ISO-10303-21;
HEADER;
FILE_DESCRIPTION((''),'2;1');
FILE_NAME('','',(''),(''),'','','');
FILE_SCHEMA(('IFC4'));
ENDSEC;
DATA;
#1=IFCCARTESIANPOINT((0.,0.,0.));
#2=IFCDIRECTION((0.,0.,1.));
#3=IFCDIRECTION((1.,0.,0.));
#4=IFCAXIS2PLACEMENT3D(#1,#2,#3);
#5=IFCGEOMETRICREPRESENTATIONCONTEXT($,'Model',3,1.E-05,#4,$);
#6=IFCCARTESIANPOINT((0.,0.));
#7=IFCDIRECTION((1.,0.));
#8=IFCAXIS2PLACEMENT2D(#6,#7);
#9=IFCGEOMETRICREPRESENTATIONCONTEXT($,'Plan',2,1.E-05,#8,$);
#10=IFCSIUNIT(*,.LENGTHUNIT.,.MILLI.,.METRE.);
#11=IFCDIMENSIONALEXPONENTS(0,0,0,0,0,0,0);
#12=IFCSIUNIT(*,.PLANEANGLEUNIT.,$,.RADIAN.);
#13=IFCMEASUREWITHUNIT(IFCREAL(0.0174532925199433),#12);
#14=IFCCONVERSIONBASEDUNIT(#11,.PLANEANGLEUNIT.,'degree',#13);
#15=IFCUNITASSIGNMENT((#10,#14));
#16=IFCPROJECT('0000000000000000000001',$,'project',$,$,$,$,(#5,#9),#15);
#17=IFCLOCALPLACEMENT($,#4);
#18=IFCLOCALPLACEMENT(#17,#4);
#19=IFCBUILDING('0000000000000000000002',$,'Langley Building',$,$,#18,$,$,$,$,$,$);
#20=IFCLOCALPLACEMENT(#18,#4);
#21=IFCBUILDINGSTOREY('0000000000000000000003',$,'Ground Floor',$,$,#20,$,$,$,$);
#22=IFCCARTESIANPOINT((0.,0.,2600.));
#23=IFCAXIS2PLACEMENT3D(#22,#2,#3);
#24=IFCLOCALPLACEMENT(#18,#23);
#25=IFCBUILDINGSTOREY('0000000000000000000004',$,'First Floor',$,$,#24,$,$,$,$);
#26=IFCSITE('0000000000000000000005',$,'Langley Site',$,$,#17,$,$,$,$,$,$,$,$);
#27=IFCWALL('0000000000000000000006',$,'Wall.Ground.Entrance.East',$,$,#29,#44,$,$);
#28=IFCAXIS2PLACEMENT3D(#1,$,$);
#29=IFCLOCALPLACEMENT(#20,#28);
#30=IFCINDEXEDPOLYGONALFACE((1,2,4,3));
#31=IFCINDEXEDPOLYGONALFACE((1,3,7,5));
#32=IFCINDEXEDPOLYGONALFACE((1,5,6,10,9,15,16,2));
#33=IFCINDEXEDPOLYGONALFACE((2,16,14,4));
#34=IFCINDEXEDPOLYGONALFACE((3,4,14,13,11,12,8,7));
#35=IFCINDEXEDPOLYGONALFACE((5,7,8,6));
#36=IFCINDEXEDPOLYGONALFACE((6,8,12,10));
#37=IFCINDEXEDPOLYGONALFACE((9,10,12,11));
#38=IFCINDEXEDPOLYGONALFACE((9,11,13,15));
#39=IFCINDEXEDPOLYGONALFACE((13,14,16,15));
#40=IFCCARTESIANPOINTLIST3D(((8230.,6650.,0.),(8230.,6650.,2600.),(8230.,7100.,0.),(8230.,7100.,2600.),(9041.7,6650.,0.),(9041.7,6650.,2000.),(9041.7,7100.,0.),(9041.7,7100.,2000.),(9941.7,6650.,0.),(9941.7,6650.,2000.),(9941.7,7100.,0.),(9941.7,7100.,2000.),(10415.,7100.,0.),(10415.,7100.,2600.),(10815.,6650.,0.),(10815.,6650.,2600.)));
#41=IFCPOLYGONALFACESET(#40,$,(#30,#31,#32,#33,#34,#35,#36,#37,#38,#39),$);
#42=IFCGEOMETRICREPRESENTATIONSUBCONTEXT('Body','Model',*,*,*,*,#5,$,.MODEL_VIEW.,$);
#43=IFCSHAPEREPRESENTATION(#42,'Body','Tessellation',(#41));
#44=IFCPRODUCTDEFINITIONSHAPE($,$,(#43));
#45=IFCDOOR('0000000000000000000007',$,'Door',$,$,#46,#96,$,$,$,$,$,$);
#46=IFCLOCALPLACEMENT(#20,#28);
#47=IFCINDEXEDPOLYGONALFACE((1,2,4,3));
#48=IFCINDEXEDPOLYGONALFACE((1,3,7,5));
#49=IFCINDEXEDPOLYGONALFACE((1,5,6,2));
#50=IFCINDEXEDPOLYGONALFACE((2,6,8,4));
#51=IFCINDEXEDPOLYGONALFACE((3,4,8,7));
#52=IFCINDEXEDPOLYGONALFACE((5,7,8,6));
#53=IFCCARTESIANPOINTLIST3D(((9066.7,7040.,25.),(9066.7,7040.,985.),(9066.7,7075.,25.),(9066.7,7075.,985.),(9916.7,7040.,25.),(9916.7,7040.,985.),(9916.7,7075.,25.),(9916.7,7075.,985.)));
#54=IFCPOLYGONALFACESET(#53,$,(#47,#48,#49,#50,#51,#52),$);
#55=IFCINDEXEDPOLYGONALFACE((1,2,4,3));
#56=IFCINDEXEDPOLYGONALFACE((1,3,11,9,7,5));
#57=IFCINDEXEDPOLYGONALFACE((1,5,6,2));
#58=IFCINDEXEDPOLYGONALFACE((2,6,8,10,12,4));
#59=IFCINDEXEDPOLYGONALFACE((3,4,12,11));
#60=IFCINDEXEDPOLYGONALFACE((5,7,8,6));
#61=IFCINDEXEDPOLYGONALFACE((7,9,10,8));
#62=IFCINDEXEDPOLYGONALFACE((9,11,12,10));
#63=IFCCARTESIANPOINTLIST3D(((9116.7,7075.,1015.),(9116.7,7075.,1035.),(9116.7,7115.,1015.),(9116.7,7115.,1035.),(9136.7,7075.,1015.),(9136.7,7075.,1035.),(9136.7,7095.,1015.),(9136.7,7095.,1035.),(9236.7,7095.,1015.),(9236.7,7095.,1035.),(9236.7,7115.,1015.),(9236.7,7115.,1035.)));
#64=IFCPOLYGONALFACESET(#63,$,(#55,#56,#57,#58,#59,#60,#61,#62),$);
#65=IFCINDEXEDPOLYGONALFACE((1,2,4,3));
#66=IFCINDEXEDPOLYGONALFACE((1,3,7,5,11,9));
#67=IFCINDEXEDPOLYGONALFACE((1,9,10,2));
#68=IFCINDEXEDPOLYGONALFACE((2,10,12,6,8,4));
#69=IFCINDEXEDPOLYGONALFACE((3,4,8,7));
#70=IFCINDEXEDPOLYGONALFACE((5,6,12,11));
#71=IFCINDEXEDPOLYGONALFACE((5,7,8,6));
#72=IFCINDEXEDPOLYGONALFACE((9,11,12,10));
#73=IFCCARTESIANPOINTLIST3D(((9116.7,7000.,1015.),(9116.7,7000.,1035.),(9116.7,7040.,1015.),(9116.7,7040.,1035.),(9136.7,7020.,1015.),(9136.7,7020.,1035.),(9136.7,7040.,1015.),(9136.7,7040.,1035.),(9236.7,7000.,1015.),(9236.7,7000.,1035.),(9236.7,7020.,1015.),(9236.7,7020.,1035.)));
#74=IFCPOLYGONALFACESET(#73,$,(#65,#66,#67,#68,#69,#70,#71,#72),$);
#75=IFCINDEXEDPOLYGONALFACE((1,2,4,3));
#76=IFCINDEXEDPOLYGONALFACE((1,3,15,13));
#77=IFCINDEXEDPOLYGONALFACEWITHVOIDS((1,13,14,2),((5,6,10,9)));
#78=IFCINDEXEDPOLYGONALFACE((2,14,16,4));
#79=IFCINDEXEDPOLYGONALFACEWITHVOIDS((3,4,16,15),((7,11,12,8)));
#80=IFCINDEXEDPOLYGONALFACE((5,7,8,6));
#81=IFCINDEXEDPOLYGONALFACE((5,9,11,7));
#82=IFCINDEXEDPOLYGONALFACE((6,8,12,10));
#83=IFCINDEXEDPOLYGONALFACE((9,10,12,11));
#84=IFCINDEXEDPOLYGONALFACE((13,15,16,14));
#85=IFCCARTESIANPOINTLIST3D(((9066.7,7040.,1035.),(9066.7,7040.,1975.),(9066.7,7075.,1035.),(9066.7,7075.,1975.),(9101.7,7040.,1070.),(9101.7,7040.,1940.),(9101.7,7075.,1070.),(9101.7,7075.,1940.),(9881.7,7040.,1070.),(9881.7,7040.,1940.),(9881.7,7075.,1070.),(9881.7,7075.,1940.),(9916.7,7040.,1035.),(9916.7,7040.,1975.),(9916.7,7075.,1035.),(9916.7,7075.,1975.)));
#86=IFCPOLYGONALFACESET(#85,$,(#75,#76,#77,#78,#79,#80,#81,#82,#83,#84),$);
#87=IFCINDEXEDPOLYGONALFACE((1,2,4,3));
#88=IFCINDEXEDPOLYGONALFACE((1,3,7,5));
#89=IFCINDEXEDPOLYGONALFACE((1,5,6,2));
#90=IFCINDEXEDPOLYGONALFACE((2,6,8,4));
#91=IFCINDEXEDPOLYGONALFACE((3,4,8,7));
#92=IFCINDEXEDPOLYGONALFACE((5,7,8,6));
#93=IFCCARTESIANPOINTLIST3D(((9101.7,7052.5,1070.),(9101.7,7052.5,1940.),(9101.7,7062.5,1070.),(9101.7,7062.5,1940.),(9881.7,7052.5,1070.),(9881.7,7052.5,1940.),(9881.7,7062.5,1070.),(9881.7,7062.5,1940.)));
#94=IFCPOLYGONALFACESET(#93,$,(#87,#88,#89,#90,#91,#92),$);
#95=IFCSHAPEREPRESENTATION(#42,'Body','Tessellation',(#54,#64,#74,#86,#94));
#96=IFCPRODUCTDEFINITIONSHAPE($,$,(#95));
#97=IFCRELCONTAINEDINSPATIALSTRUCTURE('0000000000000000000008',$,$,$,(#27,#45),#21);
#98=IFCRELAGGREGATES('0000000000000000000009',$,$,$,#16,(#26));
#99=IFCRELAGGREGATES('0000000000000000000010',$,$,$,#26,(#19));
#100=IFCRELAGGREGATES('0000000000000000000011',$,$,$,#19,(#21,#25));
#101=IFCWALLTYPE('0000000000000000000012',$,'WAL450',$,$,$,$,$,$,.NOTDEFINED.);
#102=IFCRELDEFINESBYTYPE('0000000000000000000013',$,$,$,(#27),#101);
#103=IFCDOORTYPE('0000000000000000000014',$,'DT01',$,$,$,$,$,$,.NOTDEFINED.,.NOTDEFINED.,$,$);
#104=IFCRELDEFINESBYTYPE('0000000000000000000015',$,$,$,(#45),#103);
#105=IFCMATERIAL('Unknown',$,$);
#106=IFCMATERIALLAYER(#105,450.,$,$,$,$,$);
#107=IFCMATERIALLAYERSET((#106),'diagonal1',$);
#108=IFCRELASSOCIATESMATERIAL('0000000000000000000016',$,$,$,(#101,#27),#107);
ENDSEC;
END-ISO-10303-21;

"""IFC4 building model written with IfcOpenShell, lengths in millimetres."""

from ifc_helpers import new_model, entity, si_unit, converted_unit, frame, origin_with_axes, origin_2d_with_axis, place, context, subcontext, project, spatial, line, indexed_curve, outline, extrude, shape, source, transform, mapped, material, layer, layer_set, layer_usage, type_object, type_shapes, element, fill, save


model = new_model("IFC4")

# Units and contexts
model_context = context("Model", 3, precision=1e-05, world=origin_with_axes())
plan_context = context("Plan", 2, precision=1e-05, world=origin_2d_with_axis())
body_context_1 = subcontext(model_context, "Body", "Model", "MODEL_VIEW")
body_context_2 = subcontext(plan_context, "Body", "Plan", "PLAN_VIEW")
ifc_project = project(units=[si_unit("LENGTHUNIT", "METRE", prefix="MILLI"), converted_unit("PLANEANGLEUNIT", "degree", entity("IfcReal", 0.0174532925199433), si_unit("PLANEANGLEUNIT", "RADIAN"), dimensions=[0, 0, 0, 0, 0, 0, 0])], contexts=[model_context, plan_context])

# Site, building, storey
site_placement = place(None, origin_with_axes())
site = spatial("IfcSite", under=ifc_project, at=site_placement, Name="Langley Site")
building_placement = place(site_placement, origin_with_axes())
building = spatial("IfcBuilding", under=site, at=building_placement, Name="Langley Building")
storey_1_placement = place(building_placement, origin_with_axes())
storey_1 = spatial("IfcBuildingStorey", under=building, at=storey_1_placement, Name="Ground Floor")

# Shared definitions
ifc_material = material(Name="Unknown")

# Shared definitions
storey_2_placement = place(building_placement, frame((0.0, 0.0, 2600.0), z_axis=(0.0, 0.0, 1.0), x_axis=(1.0, 0.0, 0.0)))
storey_2 = spatial("IfcBuildingStorey", under=building, at=storey_2_placement, Name="First Floor")

# Shared definitions
ifc_layer_1 = layer(ifc_material, 450.0)
ifc_layer_set_1 = layer_set([ifc_layer_1], Name="diagonal1")
wall_type_1 = type_object("IfcWallType", Name="WAL450", PredefinedType="NOTDEFINED", material=ifc_layer_set_1)

# Wall, opening, door
ifc_layer_usage_1 = layer_usage(ifc_layer_set_1, "AXIS2", "POSITIVE", 0.0)
wall_1_placement = place(storey_1_placement, frame((10815.0, 7100.0, 0.0), z_axis=(0.0, 0.0, 1.0), x_axis=(-1.0, 0.0, 0.0)))
wall_1 = element("IfcWall", 1, at=wall_1_placement, inside=storey_1, type_object=wall_type_1, material=ifc_layer_usage_1, Name="Wall.Ground.Entrance.East", context=body_context_1, shape_type="SweptSolid", body=[
    extrude(outline(indexed_curve([(400.0, 0.0), (0.0, 450.0), (2585.0, 450.0), (2585.0, 0.0)], segments=[line(1, 2, 3, 4, 1)])), origin_with_axes(), (0.0, 0.0, 1.0), 2600.0),
])
shared_shape_1 = source(origin_with_axes(), body_context_1, "Body", "SweptSolid", [
    extrude(outline(indexed_curve([(0.0, 0.0), (900.0, 0.0), (900.0, 2000.0), (0.0, 2000.0)], segments=[line(1, 2, 3, 4, 1)])), frame((0.0, -600.0, 0.0), z_axis=(0.0, -1.0, 0.0), x_axis=(1.0, 0.0, 0.0)), (0.0, 0.0, -1.0), 1200.0),
])
opening_1_placement = place(wall_1_placement, frame((873.3, 0.0, 0.0), z_axis=(0.0, 0.0, 1.0), x_axis=(1.0, 0.0, 0.0)))
opening_1 = element("IfcOpeningElement", 2, at=opening_1_placement, cuts=wall_1, PredefinedType="OPENING", context=body_context_1, shape_type="MappedRepresentation", body=[
    mapped(shared_shape_1, transform((0.0, 0.0, 0.0), x_axis=(1.0, 0.0, 0.0), y_axis=(0.0, 1.0, 0.0), z_axis=(0.0, 0.0, 1.0), scale=1.0)),
])
door_type_1 = type_object("IfcDoorType", Name="DT01", OperationType="NOTDEFINED", PredefinedType="NOTDEFINED")
shared_shape_2 = source(origin_with_axes(), body_context_1, "Body", "SweptSolid", [
    extrude(outline(indexed_curve([(0.0, 0.0), (850.0, 0.0), (850.0, 35.0), (0.0, 35.0)], segments=[line(1, 2, 3, 4, 1)])), frame((25.0, 25.0, 25.0), z_axis=(0.0, 0.0, 1.0), x_axis=(1.0, 0.0, 0.0)), (0.0, 0.0, 1.0), 960.0),
    extrude(outline(indexed_curve([(0.0, 0.0), (0.0, -40.0), (-120.0, -40.0), (-120.0, -20.0), (-20.0, -20.0), (-20.0, 0.0)], segments=[line(1, 2, 3, 4, 5, 6, 1)])), frame((825.0, 25.0, 1015.0), z_axis=(0.0, 0.0, 1.0), x_axis=(1.0, 0.0, 0.0)), (0.0, 0.0, 1.0), 20.0),
    extrude(outline(indexed_curve([(0.0, 0.0), (0.0, 40.0), (-120.0, 40.0), (-120.0, 20.0), (-20.0, 20.0), (-20.0, 0.0)], segments=[line(1, 2, 3, 4, 5, 6, 1)])), frame((825.0, 60.0, 1015.0), z_axis=(0.0, 0.0, 1.0), x_axis=(1.0, 0.0, 0.0)), (0.0, 0.0, 1.0), 20.0),
    extrude(outline(indexed_curve([(0.0, 0.0), (850.0, 0.0), (850.0, 940.0), (0.0, 940.0)], segments=[line(1, 2, 3, 4, 1)]), holes=[indexed_curve([(35.0, 35.0), (815.0, 35.0), (815.0, 905.0), (35.0, 905.0)], segments=[line(1, 2, 3, 4, 1)])]), frame((25.0, 25.0, 1035.0), z_axis=(0.0, -1.0, 0.0), x_axis=(1.0, 0.0, 0.0)), (0.0, 0.0, -1.0), 35.0),
    extrude(outline(indexed_curve([(35.0, 35.0), (815.0, 35.0), (815.0, 905.0), (35.0, 905.0)], segments=[line(1, 2, 3, 4, 1)])), frame((25.0, 37.5, 1035.0), z_axis=(0.0, -1.0, 0.0), x_axis=(1.0, 0.0, 0.0)), (0.0, 0.0, -1.0), 10.0),
])
shared_shape_3 = source(origin_with_axes(), body_context_2, "Body", "Curve2D", [
    entity("IfcIndexedPolyCurve", entity("IfcCartesianPointList2D", [[0.0, 0.0], [0.0, 50.0], [25.0, 50.0], [25.0, 25.0], [50.0, 25.0], [50.0, 0.0]]), [entity("IfcLineIndex", [1, 2, 3, 4, 5, 6, 1])]),
    entity("IfcIndexedPolyCurve", entity("IfcCartesianPointList2D", [[900.0, 0.0], [900.0, 50.0], [875.0, 50.0], [875.0, 25.0], [850.0, 25.0], [850.0, 0.0]]), [entity("IfcLineIndex", [1, 2, 3, 4, 5, 6, 1])]),
    entity("IfcTrimmedCurve", entity("IfcEllipse", entity("IfcAxis2Placement2D", entity("IfcCartesianPoint", [60.0, 50.0]), entity("IfcDirection", [1.0, 0.0])), 815.0, 850.0), [entity("IfcCartesianPoint", [875.0, 50.0])], [entity("IfcCartesianPoint", [60.0, 900.0])], True, "CARTESIAN"),
    entity("IfcIndexedPolyCurve", entity("IfcCartesianPointList2D", [[25.0, 50.0], [60.0, 50.0], [60.0, 900.0], [25.0, 900.0]]), [entity("IfcLineIndex", [1, 2, 3, 4, 1])]),
])
type_shapes(door_type_1, [shared_shape_2, shared_shape_3])
door_1_placement = place(opening_1_placement, frame((0.0, 0.0, 0.0), z_axis=(0.0, 0.0, 1.0), x_axis=(1.0, 0.0, 0.0)))
door_1 = element("IfcDoor", 3, at=door_1_placement, inside=storey_1, type_object=door_type_1, Name="Door", shapes=[
    shape(body_context_1, "Body", "MappedRepresentation", [mapped(shared_shape_2, transform((0.0, 0.0, 0.0), x_axis=(1.0, 0.0, 0.0), y_axis=(0.0, 1.0, 0.0), z_axis=(0.0, 0.0, 1.0), scale=1.0))]),
    shape(body_context_2, "Body", "MappedRepresentation", [mapped(shared_shape_3, transform((0.0, 0.0, 0.0), x_axis=(1.0, 0.0, 0.0), y_axis=(0.0, 1.0, 0.0), z_axis=(0.0, 0.0, 1.0), scale=1.0))]),
])
fill(opening_1, door_1)

save(model, "model.ifc")
